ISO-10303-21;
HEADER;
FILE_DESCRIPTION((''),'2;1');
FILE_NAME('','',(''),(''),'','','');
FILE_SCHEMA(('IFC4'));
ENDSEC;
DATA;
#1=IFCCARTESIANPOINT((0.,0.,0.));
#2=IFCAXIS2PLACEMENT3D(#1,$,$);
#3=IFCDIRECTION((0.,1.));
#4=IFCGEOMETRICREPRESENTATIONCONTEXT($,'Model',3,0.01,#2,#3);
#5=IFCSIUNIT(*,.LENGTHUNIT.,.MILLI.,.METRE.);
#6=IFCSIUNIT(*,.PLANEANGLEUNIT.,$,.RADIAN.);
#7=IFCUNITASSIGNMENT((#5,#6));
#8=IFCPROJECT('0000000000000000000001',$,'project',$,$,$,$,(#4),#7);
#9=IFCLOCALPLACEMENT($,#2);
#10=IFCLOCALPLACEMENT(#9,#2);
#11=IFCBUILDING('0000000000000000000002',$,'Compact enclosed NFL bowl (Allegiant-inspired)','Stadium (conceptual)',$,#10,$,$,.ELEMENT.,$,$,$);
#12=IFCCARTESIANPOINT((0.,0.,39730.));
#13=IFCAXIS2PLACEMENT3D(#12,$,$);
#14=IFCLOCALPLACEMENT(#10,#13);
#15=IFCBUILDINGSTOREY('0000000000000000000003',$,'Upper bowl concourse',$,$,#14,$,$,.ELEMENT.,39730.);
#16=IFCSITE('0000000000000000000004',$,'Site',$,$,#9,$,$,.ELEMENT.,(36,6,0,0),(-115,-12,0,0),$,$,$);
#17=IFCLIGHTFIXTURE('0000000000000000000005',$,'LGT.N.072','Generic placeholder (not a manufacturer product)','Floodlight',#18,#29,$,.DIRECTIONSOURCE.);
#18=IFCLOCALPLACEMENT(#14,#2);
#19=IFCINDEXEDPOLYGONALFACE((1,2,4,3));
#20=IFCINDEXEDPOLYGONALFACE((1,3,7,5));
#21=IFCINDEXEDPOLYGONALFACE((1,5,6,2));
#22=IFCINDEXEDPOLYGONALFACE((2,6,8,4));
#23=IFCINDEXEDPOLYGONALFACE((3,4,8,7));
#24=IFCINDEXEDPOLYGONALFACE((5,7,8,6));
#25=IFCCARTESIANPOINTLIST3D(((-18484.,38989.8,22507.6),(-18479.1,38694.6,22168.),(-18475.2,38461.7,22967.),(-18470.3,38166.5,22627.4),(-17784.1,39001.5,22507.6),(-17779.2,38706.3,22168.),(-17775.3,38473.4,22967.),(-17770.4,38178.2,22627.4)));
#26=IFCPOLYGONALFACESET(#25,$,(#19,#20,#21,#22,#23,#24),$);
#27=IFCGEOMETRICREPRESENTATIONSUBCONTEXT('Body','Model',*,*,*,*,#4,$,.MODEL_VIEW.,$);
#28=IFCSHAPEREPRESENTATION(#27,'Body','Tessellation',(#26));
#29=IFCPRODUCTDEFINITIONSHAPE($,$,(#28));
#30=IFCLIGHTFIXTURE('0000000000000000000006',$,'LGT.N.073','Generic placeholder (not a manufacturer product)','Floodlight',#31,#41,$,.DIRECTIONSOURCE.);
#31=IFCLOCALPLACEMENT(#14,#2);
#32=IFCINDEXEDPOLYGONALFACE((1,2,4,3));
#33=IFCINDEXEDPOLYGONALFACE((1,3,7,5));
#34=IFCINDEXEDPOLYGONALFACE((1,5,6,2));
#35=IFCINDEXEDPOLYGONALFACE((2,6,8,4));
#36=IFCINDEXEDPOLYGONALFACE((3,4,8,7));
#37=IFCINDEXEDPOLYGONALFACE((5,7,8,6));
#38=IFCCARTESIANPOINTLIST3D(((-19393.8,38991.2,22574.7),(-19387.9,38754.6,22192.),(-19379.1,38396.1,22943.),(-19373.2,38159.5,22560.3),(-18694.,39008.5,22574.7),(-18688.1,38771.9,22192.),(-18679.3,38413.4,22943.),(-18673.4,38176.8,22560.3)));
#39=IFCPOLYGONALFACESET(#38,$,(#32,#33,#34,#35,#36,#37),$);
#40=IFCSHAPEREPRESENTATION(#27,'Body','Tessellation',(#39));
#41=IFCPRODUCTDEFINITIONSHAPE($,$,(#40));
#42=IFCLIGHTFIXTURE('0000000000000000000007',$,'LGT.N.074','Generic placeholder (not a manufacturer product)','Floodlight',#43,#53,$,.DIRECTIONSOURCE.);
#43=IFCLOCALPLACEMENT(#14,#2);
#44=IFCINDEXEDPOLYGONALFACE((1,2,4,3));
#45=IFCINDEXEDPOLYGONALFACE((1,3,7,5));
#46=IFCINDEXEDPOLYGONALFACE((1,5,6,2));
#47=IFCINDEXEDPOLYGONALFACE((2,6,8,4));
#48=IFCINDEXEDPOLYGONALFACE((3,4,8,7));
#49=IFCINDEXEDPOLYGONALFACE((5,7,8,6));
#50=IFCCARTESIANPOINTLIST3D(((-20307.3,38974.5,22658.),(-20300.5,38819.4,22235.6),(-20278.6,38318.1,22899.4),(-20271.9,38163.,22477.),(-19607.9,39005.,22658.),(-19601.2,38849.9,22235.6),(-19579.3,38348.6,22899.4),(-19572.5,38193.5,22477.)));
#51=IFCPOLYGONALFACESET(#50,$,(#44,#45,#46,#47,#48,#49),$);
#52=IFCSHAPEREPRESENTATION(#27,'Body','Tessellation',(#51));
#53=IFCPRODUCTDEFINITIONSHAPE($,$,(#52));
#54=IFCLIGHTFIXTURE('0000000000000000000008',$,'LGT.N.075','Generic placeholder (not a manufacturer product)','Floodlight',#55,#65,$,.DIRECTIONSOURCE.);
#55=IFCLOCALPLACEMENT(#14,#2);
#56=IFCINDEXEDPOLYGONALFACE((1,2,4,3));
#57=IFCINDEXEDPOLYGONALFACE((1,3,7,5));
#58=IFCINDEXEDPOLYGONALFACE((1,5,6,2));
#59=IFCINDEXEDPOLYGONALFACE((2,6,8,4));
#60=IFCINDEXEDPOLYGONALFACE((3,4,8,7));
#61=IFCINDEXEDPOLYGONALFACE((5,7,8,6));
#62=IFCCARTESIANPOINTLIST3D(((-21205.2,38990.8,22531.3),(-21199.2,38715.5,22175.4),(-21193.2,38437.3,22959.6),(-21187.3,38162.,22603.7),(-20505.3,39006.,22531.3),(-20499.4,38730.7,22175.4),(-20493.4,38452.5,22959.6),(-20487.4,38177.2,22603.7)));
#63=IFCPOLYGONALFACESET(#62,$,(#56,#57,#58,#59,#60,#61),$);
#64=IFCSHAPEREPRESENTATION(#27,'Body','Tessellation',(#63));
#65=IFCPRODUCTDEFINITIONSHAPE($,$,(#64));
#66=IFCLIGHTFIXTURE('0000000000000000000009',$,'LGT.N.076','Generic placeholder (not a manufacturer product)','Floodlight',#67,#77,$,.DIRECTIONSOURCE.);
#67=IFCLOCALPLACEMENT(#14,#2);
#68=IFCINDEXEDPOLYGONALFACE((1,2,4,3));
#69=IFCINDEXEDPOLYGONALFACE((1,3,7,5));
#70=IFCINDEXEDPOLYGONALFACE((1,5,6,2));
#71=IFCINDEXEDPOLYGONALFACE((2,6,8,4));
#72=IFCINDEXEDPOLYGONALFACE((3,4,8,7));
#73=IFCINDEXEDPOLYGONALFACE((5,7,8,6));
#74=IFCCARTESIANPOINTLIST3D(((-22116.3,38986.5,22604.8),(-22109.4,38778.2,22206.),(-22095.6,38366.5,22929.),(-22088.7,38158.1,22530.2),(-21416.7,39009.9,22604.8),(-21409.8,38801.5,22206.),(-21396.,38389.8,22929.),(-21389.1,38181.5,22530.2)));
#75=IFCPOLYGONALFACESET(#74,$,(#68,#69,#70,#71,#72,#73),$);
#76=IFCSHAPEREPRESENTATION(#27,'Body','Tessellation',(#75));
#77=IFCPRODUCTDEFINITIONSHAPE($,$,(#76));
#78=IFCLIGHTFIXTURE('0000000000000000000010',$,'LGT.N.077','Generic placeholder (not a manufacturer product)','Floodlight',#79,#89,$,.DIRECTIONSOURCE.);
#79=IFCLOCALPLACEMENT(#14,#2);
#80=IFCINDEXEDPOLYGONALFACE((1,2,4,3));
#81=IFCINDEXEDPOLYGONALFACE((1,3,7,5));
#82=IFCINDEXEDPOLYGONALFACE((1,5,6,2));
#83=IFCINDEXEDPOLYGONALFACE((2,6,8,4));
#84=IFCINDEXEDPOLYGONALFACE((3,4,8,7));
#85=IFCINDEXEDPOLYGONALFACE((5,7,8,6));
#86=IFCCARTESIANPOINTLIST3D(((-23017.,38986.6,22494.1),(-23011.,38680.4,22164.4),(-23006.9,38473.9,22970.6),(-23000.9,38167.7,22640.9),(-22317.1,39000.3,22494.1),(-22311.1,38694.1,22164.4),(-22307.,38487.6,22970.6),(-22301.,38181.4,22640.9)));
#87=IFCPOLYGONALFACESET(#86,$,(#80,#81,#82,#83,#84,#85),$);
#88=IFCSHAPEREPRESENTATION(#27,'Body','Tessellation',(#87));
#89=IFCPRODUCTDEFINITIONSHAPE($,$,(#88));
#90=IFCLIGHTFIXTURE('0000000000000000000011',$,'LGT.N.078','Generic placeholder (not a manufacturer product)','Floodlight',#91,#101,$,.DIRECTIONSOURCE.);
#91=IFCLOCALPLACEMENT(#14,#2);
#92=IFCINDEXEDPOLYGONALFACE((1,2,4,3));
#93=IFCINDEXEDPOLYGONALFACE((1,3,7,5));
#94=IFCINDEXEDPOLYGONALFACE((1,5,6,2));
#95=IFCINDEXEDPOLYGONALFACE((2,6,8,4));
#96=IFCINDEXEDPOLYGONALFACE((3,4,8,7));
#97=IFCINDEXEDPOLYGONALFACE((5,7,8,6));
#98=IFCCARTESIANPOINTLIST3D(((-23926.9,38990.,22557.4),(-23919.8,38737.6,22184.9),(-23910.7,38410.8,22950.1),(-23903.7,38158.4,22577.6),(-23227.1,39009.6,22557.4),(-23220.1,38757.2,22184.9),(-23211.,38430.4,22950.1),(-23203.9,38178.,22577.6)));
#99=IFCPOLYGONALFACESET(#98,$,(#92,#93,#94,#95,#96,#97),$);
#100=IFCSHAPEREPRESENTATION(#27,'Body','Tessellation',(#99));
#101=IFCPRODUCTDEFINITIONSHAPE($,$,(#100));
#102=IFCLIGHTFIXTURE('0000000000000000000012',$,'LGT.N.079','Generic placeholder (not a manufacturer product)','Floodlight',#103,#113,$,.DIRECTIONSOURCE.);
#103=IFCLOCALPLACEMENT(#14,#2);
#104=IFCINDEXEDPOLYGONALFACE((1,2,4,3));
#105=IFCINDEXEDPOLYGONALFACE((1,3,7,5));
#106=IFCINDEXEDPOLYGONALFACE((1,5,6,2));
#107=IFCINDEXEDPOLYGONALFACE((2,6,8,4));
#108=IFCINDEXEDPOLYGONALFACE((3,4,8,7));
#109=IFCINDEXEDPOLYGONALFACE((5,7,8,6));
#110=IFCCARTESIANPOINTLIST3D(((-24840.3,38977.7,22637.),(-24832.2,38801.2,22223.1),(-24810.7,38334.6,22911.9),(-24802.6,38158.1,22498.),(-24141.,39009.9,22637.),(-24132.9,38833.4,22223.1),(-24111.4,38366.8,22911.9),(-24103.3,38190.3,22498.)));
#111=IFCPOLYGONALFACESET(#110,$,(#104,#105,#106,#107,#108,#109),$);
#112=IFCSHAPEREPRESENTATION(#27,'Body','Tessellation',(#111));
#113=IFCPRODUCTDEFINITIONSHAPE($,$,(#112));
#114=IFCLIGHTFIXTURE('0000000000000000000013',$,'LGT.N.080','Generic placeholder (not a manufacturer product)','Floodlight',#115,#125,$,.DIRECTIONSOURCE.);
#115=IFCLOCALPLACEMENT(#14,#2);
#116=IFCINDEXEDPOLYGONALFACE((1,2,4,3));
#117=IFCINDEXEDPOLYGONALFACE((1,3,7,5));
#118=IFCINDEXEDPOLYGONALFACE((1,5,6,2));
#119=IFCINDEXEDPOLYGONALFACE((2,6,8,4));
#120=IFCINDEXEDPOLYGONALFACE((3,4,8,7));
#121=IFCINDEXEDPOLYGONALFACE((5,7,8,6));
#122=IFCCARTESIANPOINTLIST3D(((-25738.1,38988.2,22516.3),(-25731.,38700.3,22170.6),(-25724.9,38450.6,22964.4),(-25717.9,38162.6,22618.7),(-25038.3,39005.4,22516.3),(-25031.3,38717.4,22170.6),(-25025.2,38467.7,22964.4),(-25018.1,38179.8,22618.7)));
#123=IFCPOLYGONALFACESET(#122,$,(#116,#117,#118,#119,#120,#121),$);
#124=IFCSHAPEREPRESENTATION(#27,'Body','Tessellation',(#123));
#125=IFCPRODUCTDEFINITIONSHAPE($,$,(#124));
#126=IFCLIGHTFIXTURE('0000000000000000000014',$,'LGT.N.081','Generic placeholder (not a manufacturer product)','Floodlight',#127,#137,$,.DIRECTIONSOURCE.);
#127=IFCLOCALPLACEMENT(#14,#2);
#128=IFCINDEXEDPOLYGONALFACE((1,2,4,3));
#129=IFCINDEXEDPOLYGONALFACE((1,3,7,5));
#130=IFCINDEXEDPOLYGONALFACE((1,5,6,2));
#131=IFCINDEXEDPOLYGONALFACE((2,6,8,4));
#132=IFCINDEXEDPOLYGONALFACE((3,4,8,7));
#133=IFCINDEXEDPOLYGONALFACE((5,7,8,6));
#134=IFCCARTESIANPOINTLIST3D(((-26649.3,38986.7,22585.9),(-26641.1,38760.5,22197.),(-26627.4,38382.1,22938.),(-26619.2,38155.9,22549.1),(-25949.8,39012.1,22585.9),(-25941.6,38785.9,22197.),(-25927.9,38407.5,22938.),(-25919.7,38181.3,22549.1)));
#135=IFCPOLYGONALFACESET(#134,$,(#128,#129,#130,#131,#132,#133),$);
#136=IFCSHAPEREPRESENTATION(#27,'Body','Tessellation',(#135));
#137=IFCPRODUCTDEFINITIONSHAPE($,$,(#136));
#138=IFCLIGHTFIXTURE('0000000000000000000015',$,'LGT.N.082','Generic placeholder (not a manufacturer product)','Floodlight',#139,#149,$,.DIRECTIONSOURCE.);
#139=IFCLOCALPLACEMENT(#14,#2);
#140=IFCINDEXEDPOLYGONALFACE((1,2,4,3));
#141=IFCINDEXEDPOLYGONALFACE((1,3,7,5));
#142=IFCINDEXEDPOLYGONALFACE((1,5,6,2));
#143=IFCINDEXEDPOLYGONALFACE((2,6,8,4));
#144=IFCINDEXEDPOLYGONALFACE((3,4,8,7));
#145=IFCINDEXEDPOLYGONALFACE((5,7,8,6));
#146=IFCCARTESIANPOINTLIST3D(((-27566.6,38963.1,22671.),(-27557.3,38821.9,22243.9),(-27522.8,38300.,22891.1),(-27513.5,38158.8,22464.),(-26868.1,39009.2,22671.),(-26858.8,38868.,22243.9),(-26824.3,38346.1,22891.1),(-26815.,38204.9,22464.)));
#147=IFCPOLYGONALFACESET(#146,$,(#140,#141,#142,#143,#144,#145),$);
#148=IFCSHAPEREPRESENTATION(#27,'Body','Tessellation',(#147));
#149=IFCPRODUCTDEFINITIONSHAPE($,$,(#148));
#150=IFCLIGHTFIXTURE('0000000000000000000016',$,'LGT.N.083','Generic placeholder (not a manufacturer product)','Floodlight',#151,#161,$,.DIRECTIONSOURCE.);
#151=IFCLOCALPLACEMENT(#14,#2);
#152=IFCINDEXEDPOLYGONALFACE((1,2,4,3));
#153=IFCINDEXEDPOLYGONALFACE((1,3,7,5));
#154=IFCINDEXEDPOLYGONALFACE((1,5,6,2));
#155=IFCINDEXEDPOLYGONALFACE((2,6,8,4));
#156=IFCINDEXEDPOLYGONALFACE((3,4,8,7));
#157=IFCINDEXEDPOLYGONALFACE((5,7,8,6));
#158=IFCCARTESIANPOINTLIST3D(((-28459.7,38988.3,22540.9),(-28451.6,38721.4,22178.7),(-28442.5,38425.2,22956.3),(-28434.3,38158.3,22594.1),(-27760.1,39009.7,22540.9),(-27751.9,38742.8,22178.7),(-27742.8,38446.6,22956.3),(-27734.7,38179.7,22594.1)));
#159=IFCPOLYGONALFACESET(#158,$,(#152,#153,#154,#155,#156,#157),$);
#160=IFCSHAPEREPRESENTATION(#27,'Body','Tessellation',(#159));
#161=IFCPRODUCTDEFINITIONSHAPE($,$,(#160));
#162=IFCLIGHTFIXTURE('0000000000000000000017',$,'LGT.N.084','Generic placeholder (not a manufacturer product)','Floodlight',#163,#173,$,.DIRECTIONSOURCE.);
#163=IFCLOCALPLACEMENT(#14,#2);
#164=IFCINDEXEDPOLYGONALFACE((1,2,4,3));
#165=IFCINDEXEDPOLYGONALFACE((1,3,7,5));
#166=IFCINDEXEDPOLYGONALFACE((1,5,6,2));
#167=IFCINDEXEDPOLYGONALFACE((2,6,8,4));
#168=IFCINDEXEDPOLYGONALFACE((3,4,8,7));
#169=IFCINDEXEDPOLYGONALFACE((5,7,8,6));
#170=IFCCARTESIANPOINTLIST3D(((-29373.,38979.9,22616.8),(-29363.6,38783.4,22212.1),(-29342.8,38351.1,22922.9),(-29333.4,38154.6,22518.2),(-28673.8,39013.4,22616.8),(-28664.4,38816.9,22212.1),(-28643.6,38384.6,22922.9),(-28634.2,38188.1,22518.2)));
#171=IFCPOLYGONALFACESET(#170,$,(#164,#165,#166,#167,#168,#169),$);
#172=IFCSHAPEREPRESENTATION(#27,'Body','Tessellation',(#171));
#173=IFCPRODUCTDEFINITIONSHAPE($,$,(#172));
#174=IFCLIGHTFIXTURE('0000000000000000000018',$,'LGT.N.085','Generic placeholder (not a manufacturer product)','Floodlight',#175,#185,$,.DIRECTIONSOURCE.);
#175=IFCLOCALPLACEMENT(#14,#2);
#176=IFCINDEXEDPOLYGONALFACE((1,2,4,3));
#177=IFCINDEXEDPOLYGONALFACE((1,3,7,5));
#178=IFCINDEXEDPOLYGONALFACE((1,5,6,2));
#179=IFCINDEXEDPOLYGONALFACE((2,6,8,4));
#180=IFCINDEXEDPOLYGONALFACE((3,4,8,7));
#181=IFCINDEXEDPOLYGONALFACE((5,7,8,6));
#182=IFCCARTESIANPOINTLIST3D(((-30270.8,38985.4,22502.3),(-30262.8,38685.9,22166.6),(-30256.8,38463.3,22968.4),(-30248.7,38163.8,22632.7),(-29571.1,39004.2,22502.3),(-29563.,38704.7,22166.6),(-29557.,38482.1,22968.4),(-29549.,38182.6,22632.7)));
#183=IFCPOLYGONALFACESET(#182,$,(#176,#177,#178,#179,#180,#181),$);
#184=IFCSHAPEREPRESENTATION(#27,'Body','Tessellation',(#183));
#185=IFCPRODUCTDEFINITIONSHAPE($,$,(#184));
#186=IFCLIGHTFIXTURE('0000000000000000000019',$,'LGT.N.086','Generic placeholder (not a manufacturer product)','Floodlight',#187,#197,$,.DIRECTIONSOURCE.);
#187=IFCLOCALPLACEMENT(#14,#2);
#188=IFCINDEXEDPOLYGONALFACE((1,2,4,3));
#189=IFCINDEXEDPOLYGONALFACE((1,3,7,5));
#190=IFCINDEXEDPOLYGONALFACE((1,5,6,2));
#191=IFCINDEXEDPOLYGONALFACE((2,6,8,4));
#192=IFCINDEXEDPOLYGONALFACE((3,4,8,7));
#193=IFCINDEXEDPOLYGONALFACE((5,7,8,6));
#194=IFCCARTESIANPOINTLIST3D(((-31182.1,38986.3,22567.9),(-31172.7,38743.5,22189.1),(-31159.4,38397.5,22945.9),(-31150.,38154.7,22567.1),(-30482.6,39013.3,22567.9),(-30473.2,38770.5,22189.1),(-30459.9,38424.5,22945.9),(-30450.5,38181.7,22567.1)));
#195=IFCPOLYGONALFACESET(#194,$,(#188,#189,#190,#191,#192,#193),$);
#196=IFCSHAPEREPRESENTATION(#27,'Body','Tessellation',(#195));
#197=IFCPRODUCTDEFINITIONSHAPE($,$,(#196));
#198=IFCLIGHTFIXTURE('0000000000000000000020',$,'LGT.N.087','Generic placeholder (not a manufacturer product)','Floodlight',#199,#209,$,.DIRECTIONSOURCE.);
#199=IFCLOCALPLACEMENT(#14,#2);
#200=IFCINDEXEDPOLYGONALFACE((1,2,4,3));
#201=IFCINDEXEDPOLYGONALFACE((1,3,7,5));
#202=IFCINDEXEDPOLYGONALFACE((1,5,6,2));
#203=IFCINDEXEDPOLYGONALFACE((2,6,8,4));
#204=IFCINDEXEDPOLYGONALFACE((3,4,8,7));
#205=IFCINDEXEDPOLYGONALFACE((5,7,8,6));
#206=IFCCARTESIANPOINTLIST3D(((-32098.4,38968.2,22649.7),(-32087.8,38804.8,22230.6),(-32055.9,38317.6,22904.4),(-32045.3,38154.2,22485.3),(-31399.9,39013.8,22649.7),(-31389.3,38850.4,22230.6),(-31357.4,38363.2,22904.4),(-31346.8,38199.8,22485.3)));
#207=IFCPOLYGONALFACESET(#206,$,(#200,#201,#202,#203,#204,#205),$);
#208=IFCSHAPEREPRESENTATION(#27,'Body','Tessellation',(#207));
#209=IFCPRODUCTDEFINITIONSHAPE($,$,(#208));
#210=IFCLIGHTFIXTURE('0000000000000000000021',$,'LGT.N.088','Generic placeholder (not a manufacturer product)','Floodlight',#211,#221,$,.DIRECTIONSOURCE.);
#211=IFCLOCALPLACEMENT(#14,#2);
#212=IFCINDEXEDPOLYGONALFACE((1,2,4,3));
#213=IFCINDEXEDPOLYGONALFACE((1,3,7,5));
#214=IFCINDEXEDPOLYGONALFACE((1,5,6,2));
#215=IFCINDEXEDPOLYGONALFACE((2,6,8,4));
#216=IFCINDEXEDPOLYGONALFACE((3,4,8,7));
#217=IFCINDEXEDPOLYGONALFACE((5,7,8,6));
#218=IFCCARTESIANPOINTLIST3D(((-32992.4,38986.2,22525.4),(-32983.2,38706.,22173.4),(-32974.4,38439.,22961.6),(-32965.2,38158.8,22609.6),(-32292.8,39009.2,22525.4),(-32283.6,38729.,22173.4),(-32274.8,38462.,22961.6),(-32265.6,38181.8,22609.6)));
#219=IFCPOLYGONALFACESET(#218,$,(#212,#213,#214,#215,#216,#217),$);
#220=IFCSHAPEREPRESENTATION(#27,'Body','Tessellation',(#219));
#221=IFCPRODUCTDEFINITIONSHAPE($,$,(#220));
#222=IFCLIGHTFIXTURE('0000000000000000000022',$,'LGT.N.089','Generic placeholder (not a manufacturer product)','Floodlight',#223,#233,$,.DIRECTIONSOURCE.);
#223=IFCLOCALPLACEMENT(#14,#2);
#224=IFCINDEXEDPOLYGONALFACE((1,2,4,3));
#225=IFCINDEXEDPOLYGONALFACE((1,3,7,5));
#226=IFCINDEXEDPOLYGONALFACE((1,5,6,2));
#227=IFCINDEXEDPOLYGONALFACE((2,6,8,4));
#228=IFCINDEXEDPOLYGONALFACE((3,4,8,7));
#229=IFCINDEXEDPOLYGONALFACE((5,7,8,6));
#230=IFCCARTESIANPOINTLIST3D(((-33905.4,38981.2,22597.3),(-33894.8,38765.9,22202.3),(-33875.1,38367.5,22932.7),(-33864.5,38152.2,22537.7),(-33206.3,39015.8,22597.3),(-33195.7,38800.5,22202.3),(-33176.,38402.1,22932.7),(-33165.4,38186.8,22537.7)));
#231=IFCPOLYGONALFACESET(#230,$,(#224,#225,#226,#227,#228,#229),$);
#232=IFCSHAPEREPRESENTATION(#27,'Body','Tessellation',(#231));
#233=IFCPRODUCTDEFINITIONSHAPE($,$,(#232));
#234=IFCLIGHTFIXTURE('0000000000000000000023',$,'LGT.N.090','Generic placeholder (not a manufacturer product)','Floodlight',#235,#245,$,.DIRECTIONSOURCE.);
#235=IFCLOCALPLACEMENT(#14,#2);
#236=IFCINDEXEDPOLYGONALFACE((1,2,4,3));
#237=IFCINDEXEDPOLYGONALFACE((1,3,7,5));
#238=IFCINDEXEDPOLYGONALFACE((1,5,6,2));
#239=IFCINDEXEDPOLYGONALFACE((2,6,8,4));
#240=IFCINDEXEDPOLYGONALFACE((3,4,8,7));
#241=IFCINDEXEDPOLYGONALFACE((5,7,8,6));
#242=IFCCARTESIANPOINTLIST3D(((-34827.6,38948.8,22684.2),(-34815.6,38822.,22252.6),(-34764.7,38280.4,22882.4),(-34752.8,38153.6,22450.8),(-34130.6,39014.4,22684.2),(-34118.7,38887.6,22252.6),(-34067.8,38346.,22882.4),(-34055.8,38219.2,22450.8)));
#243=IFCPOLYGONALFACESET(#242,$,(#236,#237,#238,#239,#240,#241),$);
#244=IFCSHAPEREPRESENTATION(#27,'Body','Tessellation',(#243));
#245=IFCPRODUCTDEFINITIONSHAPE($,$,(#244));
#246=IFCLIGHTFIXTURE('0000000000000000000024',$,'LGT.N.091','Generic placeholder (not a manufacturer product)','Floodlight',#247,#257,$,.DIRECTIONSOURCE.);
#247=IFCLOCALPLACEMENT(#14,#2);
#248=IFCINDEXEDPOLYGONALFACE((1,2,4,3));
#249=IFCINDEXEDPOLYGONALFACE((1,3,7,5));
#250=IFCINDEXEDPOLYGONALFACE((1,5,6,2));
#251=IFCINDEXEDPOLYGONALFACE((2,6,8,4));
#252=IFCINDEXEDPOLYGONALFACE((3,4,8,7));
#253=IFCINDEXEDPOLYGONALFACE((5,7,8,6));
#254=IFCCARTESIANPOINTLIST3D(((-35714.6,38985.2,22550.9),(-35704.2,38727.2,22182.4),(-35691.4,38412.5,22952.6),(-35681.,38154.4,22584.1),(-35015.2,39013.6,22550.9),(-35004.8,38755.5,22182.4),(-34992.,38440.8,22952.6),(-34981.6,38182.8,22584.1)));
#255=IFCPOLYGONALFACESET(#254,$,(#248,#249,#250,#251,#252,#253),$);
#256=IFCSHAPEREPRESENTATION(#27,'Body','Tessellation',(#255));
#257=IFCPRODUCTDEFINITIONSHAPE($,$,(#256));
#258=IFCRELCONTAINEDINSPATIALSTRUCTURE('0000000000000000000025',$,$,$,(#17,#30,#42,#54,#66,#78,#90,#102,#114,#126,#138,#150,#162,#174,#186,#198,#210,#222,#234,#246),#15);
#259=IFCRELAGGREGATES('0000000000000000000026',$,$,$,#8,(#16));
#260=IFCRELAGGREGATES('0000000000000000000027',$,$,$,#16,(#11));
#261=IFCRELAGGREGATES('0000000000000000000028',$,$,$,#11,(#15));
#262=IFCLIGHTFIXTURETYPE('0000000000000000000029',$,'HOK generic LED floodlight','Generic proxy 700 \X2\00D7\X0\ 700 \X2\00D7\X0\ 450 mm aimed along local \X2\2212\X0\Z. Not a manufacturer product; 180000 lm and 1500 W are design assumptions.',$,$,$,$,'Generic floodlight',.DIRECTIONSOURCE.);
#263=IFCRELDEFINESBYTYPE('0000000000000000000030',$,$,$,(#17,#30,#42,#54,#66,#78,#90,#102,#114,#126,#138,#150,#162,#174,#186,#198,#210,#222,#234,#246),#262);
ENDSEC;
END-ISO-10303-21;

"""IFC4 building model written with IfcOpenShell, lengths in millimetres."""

from ifc_helpers import new_model, si_unit, direction, frame, origin, place, context, subcontext, project, spatial, rectangle, extrude, source, transform, mapped, type_object, type_shapes, element, save


model = new_model("IFC4")

# Units and contexts
model_context = context("Model", 3, precision=0.01, world=origin(), true_north=direction((0.0, 1.0)))
body_context = subcontext(model_context, "Body", "Model", "MODEL_VIEW")
ifc_project = project(units=[si_unit("LENGTHUNIT", "METRE", prefix="MILLI"), si_unit("PLANEANGLEUNIT", "RADIAN")], contexts=[model_context])

# Site, building, storey
site_placement = place(None, origin())
site = spatial("IfcSite", under=ifc_project, at=site_placement, Name="Site", CompositionType="ELEMENT", RefLatitude=(36, 6, 0, 0), RefLongitude=(-115, -12, 0, 0))
building_placement = place(site_placement, origin())
building = spatial("IfcBuilding", under=site, at=building_placement, Name="Compact enclosed NFL bowl (Allegiant-inspired)", Description="Stadium (conceptual)", CompositionType="ELEMENT")
storey_placement = place(building_placement, frame((0.0, 0.0, 39730.0)))
storey = spatial("IfcBuildingStorey", under=building, at=storey_placement, Name="Upper bowl concourse", CompositionType="ELEMENT", Elevation=39730.0)

# Light fixtures
light_fixture_type = type_object("IfcLightFixtureType", Name="HOK generic LED floodlight", Description="Generic proxy 700 × 700 × 450 mm aimed along local −Z. Not a manufacturer product; 180000 lm and 1500 W are design assumptions.", ElementType="Generic floodlight", PredefinedType="DIRECTIONSOURCE")
shared_shape = source(origin(), body_context, "Body", "SweptSolid", [
    extrude(rectangle(XDim=700.0, YDim=700.0), frame((0.0, 0.0, -225.0)), (0.0, 0.0, 1.0), 450.0),
])
type_shapes(light_fixture_type, [shared_shape])
for number, where, z_axis, x_axis, name in (
    (1, (-18127.2, 38584.0, 22567.5), (-0.010978, 0.656111, 0.754584), (-0.99986, -0.01673, 0.0), "LGT.N.072"),
    (2, (-19033.6, 38584.0, 22567.5), (-0.012992, 0.525869, 0.850466), (-0.999695, -0.024698, 0.0), "LGT.N.073"),
    (3, (-19939.9, 38584.0, 22567.5), (-0.015022, 0.344623, 0.938621), (-0.999051, -0.043547, 0.0), "LGT.N.074"),
    (4, (-20846.3, 38584.0, 22567.5), (-0.013233, 0.611807, 0.790896), (-0.999766, -0.021624, 0.0), "LGT.N.075"),
    (5, (-21752.7, 38584.0, 22567.5), (-0.015473, 0.462965, 0.886242), (-0.999442, -0.033402, 0.0), "LGT.N.076"),
    (6, (-22659.0, 38584.0, 22567.5), (-0.013324, 0.680478, 0.732647), (-0.999808, -0.019577, 0.0), "LGT.N.077"),
    (7, (-23565.4, 38584.0, 22567.5), (-0.015656, 0.560895, 0.827739), (-0.999611, -0.027901, 0.0), "LGT.N.078"),
    (8, (-24471.8, 38584.0, 22567.5), (-0.018064, 0.392208, 0.919699), (-0.998941, -0.046008, 0.0), "LGT.N.079"),
    (9, (-25378.1, 38584.0, 22567.5), (-0.015649, 0.639889, 0.768308), (-0.999701, -0.024449, 0.0), "LGT.N.080"),
    (10, (-26284.5, 38584.0, 22567.5), (-0.018232, 0.502724, 0.864255), (-0.999343, -0.036243, 0.0), "LGT.N.081"),
    (11, (-27190.8, 38584.0, 22567.5), (-0.020716, 0.31375, 0.94928), (-0.997827, -0.065885, 0.0), "LGT.N.082"),
    (12, (-28097.2, 38584.0, 22567.5), (-0.018151, 0.59314, 0.804895), (-0.999532, -0.030587, 0.0), "LGT.N.083"),
    (13, (-29003.6, 38584.0, 22567.5), (-0.020934, 0.436831, 0.8993), (-0.998854, -0.047868, 0.0), "LGT.N.084"),
    (14, (-29909.9, 38584.0, 22567.5), (-0.01791, 0.665615, 0.746081), (-0.999638, -0.026898, 0.0), "LGT.N.085"),
    (15, (-30816.3, 38584.0, 22567.5), (-0.020818, 0.539521, 0.841715), (-0.999256, -0.038558, 0.0), "LGT.N.086"),
    (16, (-31722.6, 38584.0, 22567.5), (-0.023715, 0.363087, 0.931453), (-0.997874, -0.065177, 0.0), "LGT.N.087"),
    (17, (-32629.0, 38584.0, 22567.5), (-0.020483, 0.622755, 0.782149), (-0.99946, -0.032873, 0.0), "LGT.N.088"),
    (18, (-33535.4, 38584.0, 22567.5), (-0.023627, 0.478437, 0.877804), (-0.998783, -0.049323, 0.0), "LGT.N.089"),
    (19, (-34441.7, 38584.0, 22567.5), (-0.026512, 0.281848, 0.959093), (-0.995605, -0.093652, 0.0), "LGT.N.090"),
    (20, (-35348.1, 38584.0, 22567.5), (-0.023233, 0.573457, 0.818906), (-0.99918, -0.04048, 0.0), "LGT.N.091"),
):
    element("IfcLightFixture", number, at=place(storey_placement, frame(where, z_axis=z_axis, x_axis=x_axis)), inside=storey, type_object=light_fixture_type, Name=name, Description="Generic placeholder (not a manufacturer product)", ObjectType="Floodlight", PredefinedType="DIRECTIONSOURCE", context=body_context, shape_type="MappedRepresentation", body=[
        mapped(shared_shape, transform((0.0, 0.0, 0.0))),
    ])

save(model, "model.ifc")
